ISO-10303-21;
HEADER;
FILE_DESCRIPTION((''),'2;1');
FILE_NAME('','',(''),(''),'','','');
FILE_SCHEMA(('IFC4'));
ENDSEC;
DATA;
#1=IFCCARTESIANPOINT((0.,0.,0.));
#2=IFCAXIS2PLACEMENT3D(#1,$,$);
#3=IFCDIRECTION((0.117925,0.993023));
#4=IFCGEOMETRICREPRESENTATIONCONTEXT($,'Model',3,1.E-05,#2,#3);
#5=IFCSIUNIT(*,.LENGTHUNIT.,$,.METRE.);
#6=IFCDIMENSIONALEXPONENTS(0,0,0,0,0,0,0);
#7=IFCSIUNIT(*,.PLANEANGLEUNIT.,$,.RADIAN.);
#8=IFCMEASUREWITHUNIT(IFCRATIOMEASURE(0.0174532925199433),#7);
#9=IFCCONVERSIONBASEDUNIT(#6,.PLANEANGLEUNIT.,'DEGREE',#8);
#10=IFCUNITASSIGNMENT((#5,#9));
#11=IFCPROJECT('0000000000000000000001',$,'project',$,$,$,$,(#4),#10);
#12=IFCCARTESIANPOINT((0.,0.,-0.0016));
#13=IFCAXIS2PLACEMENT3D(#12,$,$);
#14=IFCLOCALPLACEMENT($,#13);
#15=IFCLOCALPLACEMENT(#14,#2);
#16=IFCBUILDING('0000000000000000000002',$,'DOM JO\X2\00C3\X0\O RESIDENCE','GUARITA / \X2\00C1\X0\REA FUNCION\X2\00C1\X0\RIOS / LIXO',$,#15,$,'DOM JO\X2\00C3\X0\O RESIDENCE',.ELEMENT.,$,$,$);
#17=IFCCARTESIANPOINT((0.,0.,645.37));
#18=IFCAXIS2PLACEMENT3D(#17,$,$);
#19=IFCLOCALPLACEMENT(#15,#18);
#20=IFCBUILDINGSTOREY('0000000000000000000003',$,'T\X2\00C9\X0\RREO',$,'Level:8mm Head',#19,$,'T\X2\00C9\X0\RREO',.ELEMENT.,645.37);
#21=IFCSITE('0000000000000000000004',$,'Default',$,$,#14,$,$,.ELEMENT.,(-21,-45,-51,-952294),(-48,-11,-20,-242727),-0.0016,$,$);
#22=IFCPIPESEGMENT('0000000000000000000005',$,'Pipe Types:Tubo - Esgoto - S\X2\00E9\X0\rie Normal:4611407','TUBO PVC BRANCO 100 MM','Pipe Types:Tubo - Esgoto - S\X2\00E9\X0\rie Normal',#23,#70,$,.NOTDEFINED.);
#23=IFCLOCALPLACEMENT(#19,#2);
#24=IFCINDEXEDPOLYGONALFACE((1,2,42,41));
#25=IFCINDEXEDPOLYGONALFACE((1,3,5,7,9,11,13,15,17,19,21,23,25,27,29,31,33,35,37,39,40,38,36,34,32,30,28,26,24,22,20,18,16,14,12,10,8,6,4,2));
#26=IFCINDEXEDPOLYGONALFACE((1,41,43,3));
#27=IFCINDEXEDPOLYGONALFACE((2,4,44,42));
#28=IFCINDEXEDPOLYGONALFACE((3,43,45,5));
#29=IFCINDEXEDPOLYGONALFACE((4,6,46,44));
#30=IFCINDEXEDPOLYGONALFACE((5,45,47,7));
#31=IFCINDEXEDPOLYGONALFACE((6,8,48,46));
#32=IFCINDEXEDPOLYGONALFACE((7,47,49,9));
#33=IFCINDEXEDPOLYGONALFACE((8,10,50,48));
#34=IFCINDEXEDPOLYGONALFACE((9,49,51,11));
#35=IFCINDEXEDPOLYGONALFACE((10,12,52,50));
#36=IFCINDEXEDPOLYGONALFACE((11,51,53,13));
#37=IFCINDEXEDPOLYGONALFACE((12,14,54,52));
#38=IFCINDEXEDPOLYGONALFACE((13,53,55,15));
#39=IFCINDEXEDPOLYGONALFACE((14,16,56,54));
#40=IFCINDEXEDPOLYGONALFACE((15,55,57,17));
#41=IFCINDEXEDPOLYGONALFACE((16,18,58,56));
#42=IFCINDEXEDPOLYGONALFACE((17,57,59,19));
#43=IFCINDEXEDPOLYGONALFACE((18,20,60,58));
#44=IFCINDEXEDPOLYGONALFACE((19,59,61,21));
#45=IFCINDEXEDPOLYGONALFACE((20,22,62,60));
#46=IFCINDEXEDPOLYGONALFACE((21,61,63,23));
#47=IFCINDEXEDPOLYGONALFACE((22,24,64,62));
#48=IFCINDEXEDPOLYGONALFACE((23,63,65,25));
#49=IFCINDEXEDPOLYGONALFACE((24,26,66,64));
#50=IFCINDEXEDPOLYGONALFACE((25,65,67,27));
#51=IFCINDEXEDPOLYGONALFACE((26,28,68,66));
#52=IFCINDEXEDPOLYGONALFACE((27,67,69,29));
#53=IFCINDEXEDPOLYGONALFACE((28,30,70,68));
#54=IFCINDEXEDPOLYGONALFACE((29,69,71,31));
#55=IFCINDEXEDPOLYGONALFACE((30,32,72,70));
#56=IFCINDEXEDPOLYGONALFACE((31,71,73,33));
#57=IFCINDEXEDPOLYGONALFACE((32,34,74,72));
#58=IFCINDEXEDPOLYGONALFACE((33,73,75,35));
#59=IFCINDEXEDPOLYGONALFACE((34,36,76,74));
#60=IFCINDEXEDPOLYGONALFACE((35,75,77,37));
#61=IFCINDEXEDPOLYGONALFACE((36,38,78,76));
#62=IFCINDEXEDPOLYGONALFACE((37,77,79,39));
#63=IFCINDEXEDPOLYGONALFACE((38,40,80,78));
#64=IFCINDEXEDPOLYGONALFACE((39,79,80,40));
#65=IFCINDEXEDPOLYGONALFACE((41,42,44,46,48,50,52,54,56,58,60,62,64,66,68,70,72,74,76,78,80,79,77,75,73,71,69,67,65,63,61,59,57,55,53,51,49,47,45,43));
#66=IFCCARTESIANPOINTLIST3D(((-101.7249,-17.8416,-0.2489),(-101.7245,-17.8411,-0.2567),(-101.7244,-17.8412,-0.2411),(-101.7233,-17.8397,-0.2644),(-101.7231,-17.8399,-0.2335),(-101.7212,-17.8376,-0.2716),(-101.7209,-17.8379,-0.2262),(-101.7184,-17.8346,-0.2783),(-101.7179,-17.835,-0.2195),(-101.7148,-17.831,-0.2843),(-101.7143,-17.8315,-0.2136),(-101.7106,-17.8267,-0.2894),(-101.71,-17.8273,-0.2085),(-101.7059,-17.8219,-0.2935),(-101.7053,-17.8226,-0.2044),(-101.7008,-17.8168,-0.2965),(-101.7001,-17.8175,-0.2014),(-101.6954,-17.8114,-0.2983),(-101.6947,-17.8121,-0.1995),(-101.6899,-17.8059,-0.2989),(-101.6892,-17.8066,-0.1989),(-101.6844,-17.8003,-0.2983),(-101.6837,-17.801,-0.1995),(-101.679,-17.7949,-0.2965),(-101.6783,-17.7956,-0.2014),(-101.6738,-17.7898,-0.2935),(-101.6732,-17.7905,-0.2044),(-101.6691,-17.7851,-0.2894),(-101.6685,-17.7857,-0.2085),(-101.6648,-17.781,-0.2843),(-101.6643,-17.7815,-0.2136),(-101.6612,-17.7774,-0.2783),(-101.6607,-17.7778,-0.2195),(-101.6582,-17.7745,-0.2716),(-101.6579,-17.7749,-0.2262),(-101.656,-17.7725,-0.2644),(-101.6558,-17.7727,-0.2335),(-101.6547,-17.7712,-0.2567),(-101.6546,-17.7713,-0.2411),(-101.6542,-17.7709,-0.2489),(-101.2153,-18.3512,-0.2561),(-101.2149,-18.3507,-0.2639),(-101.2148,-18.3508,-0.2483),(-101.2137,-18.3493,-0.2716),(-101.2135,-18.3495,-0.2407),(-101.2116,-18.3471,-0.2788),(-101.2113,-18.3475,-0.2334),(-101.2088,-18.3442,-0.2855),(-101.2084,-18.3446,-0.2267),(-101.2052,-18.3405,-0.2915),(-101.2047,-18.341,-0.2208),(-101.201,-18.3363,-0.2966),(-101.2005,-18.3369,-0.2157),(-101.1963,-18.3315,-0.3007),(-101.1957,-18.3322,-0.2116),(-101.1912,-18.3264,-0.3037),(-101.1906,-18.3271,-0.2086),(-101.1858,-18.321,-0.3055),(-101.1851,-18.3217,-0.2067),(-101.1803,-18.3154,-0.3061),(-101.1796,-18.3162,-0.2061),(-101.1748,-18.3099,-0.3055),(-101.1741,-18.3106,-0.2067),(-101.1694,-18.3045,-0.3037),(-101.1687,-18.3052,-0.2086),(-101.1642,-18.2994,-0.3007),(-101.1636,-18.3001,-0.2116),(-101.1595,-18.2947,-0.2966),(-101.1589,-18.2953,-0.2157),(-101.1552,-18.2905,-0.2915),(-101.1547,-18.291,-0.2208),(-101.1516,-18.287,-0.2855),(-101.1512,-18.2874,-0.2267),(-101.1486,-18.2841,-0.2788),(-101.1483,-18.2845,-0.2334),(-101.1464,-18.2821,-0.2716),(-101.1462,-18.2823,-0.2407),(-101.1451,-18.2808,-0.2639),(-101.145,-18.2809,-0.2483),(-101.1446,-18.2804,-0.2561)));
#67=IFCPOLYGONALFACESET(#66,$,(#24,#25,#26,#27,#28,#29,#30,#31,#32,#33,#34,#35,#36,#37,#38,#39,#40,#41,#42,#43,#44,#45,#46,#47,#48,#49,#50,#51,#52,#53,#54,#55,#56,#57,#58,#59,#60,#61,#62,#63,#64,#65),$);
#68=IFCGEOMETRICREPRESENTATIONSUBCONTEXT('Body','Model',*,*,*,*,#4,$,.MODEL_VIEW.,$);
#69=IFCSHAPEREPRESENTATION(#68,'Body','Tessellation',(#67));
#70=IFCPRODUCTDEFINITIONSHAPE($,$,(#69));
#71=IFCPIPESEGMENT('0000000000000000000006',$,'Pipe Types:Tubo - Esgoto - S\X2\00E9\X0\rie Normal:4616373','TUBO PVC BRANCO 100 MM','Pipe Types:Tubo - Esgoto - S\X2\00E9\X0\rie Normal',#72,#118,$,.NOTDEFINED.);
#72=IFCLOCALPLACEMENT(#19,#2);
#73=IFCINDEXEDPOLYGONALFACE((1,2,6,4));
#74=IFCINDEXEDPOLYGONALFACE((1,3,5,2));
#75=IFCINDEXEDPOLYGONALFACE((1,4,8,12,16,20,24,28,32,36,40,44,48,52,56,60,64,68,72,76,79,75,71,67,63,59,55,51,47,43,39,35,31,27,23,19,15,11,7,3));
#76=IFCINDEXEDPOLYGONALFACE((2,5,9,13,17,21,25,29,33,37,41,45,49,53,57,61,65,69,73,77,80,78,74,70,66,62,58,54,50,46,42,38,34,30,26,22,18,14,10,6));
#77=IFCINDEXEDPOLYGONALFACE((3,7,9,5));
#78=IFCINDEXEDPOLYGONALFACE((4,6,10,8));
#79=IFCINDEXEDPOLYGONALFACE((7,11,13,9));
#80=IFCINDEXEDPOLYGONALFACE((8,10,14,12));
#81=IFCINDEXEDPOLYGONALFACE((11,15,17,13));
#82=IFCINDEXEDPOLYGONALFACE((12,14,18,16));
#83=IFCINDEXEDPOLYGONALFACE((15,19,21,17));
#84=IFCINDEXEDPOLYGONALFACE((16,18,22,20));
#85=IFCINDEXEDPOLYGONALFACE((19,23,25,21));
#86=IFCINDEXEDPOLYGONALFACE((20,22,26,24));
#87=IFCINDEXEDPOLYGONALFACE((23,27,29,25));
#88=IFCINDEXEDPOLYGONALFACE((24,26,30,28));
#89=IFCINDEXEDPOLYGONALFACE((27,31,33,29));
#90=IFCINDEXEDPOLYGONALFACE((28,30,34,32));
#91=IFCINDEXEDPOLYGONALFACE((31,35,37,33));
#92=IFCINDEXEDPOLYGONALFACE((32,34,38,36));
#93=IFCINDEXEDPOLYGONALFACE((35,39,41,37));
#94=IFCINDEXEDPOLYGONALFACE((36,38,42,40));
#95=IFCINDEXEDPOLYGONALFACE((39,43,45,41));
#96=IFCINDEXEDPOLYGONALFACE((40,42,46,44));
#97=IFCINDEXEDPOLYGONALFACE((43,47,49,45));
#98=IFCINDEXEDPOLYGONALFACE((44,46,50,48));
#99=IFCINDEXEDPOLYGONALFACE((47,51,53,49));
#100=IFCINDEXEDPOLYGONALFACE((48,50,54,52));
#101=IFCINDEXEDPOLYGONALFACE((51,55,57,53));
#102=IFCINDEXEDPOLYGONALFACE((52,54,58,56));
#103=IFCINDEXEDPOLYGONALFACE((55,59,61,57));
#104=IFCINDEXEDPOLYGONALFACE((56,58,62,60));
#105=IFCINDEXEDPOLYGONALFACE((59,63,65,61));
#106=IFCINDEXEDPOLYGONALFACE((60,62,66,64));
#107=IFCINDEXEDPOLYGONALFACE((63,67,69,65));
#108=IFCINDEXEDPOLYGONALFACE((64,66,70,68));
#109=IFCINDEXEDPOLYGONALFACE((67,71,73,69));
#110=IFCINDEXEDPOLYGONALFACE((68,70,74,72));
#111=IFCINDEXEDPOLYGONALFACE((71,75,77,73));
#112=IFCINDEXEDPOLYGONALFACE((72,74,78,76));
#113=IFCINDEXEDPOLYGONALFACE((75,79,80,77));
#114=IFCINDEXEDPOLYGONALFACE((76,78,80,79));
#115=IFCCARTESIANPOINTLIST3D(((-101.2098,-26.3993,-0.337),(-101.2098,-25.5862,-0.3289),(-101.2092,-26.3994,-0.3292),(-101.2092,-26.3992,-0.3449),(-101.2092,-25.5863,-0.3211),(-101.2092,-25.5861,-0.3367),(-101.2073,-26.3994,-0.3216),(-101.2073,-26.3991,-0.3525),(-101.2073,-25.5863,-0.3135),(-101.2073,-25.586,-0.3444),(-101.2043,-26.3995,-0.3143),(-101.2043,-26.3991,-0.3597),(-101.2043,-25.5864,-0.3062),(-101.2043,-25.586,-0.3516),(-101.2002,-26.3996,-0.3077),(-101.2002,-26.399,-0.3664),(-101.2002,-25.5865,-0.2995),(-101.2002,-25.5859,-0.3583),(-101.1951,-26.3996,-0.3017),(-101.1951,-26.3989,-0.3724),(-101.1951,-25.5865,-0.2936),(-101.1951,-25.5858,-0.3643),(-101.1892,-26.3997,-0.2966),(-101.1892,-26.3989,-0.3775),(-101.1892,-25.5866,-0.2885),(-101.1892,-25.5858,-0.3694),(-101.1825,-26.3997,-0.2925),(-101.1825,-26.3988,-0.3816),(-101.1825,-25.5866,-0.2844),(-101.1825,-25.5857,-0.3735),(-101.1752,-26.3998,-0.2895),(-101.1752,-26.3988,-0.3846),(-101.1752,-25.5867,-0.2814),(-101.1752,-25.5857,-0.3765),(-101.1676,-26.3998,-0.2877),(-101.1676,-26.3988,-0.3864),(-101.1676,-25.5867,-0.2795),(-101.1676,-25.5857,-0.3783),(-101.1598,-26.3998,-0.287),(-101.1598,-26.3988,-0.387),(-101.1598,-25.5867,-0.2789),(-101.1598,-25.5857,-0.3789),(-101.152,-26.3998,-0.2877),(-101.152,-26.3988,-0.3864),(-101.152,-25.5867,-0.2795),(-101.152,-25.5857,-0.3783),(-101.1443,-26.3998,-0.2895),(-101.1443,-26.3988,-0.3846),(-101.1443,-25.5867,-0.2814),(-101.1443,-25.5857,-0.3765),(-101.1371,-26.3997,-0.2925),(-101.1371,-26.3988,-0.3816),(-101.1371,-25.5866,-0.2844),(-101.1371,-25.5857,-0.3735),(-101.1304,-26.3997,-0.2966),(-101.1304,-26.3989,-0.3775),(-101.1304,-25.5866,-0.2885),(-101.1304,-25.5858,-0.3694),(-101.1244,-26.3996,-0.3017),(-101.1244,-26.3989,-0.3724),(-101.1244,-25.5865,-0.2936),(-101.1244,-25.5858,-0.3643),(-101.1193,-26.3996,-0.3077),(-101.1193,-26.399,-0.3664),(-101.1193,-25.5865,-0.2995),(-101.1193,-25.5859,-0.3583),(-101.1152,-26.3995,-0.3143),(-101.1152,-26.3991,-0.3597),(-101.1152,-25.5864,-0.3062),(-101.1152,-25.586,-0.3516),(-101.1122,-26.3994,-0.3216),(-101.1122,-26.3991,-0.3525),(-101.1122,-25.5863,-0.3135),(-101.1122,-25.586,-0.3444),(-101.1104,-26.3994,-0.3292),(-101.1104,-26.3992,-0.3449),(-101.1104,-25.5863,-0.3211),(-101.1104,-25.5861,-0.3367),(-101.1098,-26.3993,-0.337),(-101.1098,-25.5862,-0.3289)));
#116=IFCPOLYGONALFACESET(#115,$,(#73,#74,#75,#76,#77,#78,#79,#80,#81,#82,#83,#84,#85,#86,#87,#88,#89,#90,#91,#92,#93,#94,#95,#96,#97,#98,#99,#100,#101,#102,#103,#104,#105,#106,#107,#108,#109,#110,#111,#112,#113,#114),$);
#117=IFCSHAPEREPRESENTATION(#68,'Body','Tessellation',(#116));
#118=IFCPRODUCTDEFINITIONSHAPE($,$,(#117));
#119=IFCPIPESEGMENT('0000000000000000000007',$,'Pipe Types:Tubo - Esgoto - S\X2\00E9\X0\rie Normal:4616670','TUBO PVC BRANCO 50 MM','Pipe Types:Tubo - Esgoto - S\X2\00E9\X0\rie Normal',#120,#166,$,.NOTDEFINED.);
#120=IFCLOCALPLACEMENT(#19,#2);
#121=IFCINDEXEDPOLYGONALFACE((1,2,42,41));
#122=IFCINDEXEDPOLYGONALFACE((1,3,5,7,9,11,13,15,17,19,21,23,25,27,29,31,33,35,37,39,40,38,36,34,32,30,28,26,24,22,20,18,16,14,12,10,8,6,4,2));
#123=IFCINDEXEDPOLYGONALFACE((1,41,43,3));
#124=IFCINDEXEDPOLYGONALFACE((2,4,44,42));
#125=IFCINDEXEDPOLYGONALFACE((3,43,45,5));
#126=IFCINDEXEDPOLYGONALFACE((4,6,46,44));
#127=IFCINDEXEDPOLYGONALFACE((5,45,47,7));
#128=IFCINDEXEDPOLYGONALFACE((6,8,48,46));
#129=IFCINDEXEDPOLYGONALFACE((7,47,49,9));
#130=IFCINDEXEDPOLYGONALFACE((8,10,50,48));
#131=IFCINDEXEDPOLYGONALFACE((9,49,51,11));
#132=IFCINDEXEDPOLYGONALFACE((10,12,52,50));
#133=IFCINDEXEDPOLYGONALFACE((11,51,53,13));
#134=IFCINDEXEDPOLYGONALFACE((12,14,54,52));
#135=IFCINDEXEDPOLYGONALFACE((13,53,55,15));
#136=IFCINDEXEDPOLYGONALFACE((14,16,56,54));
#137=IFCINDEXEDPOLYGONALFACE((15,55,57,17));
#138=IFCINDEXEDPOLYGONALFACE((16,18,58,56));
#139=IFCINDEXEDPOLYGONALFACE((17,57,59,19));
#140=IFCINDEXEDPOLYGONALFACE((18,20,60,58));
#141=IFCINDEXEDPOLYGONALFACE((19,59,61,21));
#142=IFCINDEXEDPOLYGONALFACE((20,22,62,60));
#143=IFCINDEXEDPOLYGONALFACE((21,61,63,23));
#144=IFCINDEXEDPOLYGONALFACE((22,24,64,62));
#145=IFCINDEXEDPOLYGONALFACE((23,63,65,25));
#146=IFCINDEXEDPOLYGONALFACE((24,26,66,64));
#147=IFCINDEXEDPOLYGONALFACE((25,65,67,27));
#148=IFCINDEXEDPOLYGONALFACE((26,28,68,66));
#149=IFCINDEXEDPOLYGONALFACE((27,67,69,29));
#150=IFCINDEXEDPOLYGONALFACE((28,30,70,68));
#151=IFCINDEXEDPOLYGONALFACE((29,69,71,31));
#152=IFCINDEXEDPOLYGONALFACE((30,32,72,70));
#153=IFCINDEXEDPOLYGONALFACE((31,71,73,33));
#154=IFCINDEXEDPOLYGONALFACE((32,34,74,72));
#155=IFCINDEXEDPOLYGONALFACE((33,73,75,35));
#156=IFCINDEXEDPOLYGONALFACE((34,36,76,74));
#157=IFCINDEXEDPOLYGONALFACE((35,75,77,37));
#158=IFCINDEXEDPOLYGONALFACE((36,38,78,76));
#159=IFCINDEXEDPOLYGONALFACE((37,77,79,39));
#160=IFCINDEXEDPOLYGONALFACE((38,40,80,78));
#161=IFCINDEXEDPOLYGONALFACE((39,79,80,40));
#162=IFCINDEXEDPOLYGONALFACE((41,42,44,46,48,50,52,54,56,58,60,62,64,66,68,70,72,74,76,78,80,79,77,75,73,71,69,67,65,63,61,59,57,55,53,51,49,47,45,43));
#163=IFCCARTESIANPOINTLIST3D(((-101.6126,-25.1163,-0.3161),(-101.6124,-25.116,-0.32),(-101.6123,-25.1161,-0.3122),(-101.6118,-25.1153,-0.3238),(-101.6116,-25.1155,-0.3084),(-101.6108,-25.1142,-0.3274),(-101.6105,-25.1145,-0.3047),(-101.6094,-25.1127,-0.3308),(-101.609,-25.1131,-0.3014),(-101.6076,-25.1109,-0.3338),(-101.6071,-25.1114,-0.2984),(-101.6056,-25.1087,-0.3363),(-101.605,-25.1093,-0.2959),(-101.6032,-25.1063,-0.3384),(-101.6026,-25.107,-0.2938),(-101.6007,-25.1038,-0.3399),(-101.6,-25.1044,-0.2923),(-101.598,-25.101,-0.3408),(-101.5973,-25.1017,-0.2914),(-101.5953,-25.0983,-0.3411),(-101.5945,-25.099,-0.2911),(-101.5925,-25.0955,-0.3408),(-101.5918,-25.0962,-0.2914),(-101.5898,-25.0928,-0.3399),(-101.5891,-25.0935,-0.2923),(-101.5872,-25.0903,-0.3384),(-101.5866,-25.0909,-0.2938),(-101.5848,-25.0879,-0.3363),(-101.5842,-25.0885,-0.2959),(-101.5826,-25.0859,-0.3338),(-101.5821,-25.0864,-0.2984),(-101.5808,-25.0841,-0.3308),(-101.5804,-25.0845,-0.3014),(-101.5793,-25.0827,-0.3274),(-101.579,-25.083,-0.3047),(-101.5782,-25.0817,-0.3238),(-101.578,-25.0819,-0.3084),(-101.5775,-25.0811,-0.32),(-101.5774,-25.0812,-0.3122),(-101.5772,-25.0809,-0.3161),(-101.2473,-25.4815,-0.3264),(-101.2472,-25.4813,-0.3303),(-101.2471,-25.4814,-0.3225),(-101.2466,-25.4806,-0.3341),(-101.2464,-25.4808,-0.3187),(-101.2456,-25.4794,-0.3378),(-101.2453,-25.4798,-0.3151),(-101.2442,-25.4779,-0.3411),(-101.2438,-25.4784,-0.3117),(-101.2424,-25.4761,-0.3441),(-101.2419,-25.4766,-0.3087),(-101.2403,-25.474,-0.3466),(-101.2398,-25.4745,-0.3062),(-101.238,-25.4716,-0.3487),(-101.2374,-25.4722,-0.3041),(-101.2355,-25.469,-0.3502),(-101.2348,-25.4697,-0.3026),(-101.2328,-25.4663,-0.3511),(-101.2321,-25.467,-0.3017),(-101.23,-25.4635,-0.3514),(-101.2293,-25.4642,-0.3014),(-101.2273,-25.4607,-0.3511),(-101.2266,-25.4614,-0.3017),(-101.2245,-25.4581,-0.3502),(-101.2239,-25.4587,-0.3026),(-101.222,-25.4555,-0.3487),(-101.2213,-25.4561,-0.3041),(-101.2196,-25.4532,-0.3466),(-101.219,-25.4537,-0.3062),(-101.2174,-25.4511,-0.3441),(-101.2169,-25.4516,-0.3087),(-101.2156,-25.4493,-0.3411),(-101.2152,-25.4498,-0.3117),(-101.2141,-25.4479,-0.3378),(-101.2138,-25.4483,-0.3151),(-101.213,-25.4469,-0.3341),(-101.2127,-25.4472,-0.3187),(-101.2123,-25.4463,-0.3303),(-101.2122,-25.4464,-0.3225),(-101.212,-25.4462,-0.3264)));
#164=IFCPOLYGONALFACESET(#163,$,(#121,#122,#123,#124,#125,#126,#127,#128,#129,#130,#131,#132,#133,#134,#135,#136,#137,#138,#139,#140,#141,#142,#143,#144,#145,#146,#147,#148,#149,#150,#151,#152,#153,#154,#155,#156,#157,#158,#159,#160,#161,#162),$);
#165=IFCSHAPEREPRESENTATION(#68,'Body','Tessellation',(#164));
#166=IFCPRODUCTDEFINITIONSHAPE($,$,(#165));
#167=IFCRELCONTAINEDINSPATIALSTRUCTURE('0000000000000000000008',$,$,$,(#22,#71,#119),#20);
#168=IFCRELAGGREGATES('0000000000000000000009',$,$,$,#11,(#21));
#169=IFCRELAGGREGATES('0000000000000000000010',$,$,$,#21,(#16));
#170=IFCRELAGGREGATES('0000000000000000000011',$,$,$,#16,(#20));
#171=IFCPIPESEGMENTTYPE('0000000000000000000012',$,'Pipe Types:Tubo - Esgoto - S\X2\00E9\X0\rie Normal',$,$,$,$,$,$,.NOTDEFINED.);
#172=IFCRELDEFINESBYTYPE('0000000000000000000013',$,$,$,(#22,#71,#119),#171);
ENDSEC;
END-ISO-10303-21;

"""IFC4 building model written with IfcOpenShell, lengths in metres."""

from ifc_helpers import new_model, entity, si_unit, converted_unit, direction, frame, origin, place, context, subcontext, project, spatial, indexed_curve, outline, extrude, type_object, element, save


model = new_model("IFC4")

# Units and contexts
model_context = context("Model", 3, precision=1e-05, world=origin(), true_north=direction((0.117925, 0.993023)))
body_context = subcontext(model_context, "Body", "Model", "MODEL_VIEW")
ifc_project = project(units=[si_unit("LENGTHUNIT", "METRE"), converted_unit("PLANEANGLEUNIT", "DEGREE", entity("IfcRatioMeasure", 0.0174532925199433), si_unit("PLANEANGLEUNIT", "RADIAN"), dimensions=[0, 0, 0, 0, 0, 0, 0])], contexts=[model_context])

# Site, building, storey
site_placement = place(None, frame((0.0, 0.0, -0.0016)))
site = spatial("IfcSite", under=ifc_project, at=site_placement, Name="Default", CompositionType="ELEMENT", RefLatitude=(-21, -45, -51, -952294), RefLongitude=(-48, -11, -20, -242727), RefElevation=-0.0016)
building_placement = place(site_placement, origin())
building = spatial("IfcBuilding", under=site, at=building_placement, Name="DOM JOÃO RESIDENCE", Description="GUARITA / ÁREA FUNCIONÁRIOS / LIXO", LongName="DOM JOÃO RESIDENCE", CompositionType="ELEMENT")
storey_placement = place(building_placement, frame((0.0, 0.0, 645.37)))
storey = spatial("IfcBuildingStorey", under=building, at=storey_placement, Name="TÉRREO", ObjectType="Level:8mm Head", LongName="TÉRREO", CompositionType="ELEMENT", Elevation=645.37)

# Pipe segments
pipe_segment_type_1 = type_object("IfcPipeSegmentType", Name="Pipe Types:Tubo - Esgoto - Série Normal", PredefinedType="NOTDEFINED")
pipe_segment_1_placement = place(storey_placement, frame((-101.7265, -18.3528, -0.3077)))
element("IfcPipeSegment", 1, at=pipe_segment_1_placement, inside=storey, type_object=pipe_segment_type_1, Name="Pipe Types:Tubo - Esgoto - Série Normal:4611407", Description="TUBO PVC BRANCO 100 MM", ObjectType="Pipe Types:Tubo - Esgoto - Série Normal", PredefinedType="NOTDEFINED", context=body_context, shape_type="SweptSolid", body=[
    extrude(outline(indexed_curve([(0.05, 0.0), (0.0494, 0.0078), (0.0476, 0.0155), (0.0446, 0.0227), (0.0405, 0.0294), (0.0354, 0.0354), (0.0294, 0.0405), (0.0227, 0.0446), (0.0155, 0.0476), (0.0078, 0.0494), (0.0, 0.05), (-0.0078, 0.0494), (-0.0155, 0.0476), (-0.0227, 0.0446), (-0.0294, 0.0405), (-0.0354, 0.0354), (-0.0405, 0.0294), (-0.0446, 0.0227), (-0.0476, 0.0155), (-0.0494, 0.0078), (-0.05, 0.0), (-0.0494, -0.0078), (-0.0476, -0.0155), (-0.0446, -0.0227), (-0.0405, -0.0294), (-0.0354, -0.0354), (-0.0294, -0.0405), (-0.0227, -0.0446), (-0.0155, -0.0476), (-0.0078, -0.0494), (0.0, -0.05), (0.0078, -0.0494), (0.0155, -0.0476), (0.0227, -0.0446), (0.0294, -0.0405), (0.0354, -0.0354), (0.0405, -0.0294), (0.0446, -0.0227), (0.0476, -0.0155), (0.0494, -0.0078), (0.05, 0.0)], self_intersect=False)), frame((0.5465, 0.037, 0.0516), z_axis=(-0.707071, 0.707071, 0.01), x_axis=(-0.707107, -0.707107, 0.0)), (0.0, 0.0, 1.0), 0.7207),
])
pipe_segment_2_placement = place(storey_placement, frame((-101.2114, -26.4014, -0.3886)))
element("IfcPipeSegment", 2, at=pipe_segment_2_placement, inside=storey, type_object=pipe_segment_type_1, Name="Pipe Types:Tubo - Esgoto - Série Normal:4616373", Description="TUBO PVC BRANCO 100 MM", ObjectType="Pipe Types:Tubo - Esgoto - Série Normal", PredefinedType="NOTDEFINED", context=body_context, shape_type="SweptSolid", body=[
    extrude(outline(indexed_curve([(0.05, 0.0), (0.0494, 0.0078), (0.0476, 0.0155), (0.0446, 0.0227), (0.0405, 0.0294), (0.0354, 0.0354), (0.0294, 0.0405), (0.0227, 0.0446), (0.0155, 0.0476), (0.0078, 0.0494), (0.0, 0.05), (-0.0078, 0.0494), (-0.0155, 0.0476), (-0.0227, 0.0446), (-0.0294, 0.0405), (-0.0354, 0.0354), (-0.0405, 0.0294), (-0.0446, 0.0227), (-0.0476, 0.0155), (-0.0494, 0.0078), (-0.05, 0.0), (-0.0494, -0.0078), (-0.0476, -0.0155), (-0.0446, -0.0227), (-0.0405, -0.0294), (-0.0354, -0.0354), (-0.0294, -0.0405), (-0.0227, -0.0446), (-0.0155, -0.0476), (-0.0078, -0.0494), (0.0, -0.05), (0.0078, -0.0494), (0.0155, -0.0476), (0.0227, -0.0446), (0.0294, -0.0405), (0.0354, -0.0354), (0.0405, -0.0294), (0.0446, -0.0227), (0.0476, -0.0155), (0.0494, -0.0078), (0.05, 0.0)], self_intersect=False)), frame((0.0516, 0.0021, 0.0516), z_axis=(0.0, 0.99995, 0.01), x_axis=(-1.0, 0.0, 0.0)), (0.0, 0.0, 1.0), 0.8132),
])
pipe_segment_3_placement = place(storey_placement, frame((-101.6142, -25.4831, -0.353)))
element("IfcPipeSegment", 3, at=pipe_segment_3_placement, inside=storey, type_object=pipe_segment_type_1, Name="Pipe Types:Tubo - Esgoto - Série Normal:4616670", Description="TUBO PVC BRANCO 50 MM", ObjectType="Pipe Types:Tubo - Esgoto - Série Normal", PredefinedType="NOTDEFINED", context=body_context, shape_type="SweptSolid", body=[
    extrude(outline(indexed_curve([(0.025, 0.0), (0.0247, 0.0039), (0.0238, 0.0077), (0.0223, 0.0113), (0.0202, 0.0147), (0.0177, 0.0177), (0.0147, 0.0202), (0.0113, 0.0223), (0.0077, 0.0238), (0.0039, 0.0247), (0.0, 0.025), (-0.0039, 0.0247), (-0.0077, 0.0238), (-0.0113, 0.0223), (-0.0147, 0.0202), (-0.0177, 0.0177), (-0.0202, 0.0147), (-0.0223, 0.0113), (-0.0238, 0.0077), (-0.0247, 0.0039), (-0.025, 0.0), (-0.0247, -0.0039), (-0.0238, -0.0077), (-0.0223, -0.0113), (-0.0202, -0.0147), (-0.0177, -0.0177), (-0.0147, -0.0202), (-0.0113, -0.0223), (-0.0077, -0.0238), (-0.0039, -0.0247), (0.0, -0.025), (0.0039, -0.0247), (0.0077, -0.0238), (0.0113, -0.0223), (0.0147, -0.0202), (0.0177, -0.0177), (0.0202, -0.0147), (0.0223, -0.0113), (0.0238, -0.0077), (0.0247, -0.0039), (0.025, 0.0)], self_intersect=False)), frame((0.3845, 0.0193, 0.0266), z_axis=(-0.706965, 0.706965, 0.019996), x_axis=(0.707107, 0.707107, 0.0)), (0.0, 0.0, 1.0), 0.5166),
])

save(model, "model.ifc")
